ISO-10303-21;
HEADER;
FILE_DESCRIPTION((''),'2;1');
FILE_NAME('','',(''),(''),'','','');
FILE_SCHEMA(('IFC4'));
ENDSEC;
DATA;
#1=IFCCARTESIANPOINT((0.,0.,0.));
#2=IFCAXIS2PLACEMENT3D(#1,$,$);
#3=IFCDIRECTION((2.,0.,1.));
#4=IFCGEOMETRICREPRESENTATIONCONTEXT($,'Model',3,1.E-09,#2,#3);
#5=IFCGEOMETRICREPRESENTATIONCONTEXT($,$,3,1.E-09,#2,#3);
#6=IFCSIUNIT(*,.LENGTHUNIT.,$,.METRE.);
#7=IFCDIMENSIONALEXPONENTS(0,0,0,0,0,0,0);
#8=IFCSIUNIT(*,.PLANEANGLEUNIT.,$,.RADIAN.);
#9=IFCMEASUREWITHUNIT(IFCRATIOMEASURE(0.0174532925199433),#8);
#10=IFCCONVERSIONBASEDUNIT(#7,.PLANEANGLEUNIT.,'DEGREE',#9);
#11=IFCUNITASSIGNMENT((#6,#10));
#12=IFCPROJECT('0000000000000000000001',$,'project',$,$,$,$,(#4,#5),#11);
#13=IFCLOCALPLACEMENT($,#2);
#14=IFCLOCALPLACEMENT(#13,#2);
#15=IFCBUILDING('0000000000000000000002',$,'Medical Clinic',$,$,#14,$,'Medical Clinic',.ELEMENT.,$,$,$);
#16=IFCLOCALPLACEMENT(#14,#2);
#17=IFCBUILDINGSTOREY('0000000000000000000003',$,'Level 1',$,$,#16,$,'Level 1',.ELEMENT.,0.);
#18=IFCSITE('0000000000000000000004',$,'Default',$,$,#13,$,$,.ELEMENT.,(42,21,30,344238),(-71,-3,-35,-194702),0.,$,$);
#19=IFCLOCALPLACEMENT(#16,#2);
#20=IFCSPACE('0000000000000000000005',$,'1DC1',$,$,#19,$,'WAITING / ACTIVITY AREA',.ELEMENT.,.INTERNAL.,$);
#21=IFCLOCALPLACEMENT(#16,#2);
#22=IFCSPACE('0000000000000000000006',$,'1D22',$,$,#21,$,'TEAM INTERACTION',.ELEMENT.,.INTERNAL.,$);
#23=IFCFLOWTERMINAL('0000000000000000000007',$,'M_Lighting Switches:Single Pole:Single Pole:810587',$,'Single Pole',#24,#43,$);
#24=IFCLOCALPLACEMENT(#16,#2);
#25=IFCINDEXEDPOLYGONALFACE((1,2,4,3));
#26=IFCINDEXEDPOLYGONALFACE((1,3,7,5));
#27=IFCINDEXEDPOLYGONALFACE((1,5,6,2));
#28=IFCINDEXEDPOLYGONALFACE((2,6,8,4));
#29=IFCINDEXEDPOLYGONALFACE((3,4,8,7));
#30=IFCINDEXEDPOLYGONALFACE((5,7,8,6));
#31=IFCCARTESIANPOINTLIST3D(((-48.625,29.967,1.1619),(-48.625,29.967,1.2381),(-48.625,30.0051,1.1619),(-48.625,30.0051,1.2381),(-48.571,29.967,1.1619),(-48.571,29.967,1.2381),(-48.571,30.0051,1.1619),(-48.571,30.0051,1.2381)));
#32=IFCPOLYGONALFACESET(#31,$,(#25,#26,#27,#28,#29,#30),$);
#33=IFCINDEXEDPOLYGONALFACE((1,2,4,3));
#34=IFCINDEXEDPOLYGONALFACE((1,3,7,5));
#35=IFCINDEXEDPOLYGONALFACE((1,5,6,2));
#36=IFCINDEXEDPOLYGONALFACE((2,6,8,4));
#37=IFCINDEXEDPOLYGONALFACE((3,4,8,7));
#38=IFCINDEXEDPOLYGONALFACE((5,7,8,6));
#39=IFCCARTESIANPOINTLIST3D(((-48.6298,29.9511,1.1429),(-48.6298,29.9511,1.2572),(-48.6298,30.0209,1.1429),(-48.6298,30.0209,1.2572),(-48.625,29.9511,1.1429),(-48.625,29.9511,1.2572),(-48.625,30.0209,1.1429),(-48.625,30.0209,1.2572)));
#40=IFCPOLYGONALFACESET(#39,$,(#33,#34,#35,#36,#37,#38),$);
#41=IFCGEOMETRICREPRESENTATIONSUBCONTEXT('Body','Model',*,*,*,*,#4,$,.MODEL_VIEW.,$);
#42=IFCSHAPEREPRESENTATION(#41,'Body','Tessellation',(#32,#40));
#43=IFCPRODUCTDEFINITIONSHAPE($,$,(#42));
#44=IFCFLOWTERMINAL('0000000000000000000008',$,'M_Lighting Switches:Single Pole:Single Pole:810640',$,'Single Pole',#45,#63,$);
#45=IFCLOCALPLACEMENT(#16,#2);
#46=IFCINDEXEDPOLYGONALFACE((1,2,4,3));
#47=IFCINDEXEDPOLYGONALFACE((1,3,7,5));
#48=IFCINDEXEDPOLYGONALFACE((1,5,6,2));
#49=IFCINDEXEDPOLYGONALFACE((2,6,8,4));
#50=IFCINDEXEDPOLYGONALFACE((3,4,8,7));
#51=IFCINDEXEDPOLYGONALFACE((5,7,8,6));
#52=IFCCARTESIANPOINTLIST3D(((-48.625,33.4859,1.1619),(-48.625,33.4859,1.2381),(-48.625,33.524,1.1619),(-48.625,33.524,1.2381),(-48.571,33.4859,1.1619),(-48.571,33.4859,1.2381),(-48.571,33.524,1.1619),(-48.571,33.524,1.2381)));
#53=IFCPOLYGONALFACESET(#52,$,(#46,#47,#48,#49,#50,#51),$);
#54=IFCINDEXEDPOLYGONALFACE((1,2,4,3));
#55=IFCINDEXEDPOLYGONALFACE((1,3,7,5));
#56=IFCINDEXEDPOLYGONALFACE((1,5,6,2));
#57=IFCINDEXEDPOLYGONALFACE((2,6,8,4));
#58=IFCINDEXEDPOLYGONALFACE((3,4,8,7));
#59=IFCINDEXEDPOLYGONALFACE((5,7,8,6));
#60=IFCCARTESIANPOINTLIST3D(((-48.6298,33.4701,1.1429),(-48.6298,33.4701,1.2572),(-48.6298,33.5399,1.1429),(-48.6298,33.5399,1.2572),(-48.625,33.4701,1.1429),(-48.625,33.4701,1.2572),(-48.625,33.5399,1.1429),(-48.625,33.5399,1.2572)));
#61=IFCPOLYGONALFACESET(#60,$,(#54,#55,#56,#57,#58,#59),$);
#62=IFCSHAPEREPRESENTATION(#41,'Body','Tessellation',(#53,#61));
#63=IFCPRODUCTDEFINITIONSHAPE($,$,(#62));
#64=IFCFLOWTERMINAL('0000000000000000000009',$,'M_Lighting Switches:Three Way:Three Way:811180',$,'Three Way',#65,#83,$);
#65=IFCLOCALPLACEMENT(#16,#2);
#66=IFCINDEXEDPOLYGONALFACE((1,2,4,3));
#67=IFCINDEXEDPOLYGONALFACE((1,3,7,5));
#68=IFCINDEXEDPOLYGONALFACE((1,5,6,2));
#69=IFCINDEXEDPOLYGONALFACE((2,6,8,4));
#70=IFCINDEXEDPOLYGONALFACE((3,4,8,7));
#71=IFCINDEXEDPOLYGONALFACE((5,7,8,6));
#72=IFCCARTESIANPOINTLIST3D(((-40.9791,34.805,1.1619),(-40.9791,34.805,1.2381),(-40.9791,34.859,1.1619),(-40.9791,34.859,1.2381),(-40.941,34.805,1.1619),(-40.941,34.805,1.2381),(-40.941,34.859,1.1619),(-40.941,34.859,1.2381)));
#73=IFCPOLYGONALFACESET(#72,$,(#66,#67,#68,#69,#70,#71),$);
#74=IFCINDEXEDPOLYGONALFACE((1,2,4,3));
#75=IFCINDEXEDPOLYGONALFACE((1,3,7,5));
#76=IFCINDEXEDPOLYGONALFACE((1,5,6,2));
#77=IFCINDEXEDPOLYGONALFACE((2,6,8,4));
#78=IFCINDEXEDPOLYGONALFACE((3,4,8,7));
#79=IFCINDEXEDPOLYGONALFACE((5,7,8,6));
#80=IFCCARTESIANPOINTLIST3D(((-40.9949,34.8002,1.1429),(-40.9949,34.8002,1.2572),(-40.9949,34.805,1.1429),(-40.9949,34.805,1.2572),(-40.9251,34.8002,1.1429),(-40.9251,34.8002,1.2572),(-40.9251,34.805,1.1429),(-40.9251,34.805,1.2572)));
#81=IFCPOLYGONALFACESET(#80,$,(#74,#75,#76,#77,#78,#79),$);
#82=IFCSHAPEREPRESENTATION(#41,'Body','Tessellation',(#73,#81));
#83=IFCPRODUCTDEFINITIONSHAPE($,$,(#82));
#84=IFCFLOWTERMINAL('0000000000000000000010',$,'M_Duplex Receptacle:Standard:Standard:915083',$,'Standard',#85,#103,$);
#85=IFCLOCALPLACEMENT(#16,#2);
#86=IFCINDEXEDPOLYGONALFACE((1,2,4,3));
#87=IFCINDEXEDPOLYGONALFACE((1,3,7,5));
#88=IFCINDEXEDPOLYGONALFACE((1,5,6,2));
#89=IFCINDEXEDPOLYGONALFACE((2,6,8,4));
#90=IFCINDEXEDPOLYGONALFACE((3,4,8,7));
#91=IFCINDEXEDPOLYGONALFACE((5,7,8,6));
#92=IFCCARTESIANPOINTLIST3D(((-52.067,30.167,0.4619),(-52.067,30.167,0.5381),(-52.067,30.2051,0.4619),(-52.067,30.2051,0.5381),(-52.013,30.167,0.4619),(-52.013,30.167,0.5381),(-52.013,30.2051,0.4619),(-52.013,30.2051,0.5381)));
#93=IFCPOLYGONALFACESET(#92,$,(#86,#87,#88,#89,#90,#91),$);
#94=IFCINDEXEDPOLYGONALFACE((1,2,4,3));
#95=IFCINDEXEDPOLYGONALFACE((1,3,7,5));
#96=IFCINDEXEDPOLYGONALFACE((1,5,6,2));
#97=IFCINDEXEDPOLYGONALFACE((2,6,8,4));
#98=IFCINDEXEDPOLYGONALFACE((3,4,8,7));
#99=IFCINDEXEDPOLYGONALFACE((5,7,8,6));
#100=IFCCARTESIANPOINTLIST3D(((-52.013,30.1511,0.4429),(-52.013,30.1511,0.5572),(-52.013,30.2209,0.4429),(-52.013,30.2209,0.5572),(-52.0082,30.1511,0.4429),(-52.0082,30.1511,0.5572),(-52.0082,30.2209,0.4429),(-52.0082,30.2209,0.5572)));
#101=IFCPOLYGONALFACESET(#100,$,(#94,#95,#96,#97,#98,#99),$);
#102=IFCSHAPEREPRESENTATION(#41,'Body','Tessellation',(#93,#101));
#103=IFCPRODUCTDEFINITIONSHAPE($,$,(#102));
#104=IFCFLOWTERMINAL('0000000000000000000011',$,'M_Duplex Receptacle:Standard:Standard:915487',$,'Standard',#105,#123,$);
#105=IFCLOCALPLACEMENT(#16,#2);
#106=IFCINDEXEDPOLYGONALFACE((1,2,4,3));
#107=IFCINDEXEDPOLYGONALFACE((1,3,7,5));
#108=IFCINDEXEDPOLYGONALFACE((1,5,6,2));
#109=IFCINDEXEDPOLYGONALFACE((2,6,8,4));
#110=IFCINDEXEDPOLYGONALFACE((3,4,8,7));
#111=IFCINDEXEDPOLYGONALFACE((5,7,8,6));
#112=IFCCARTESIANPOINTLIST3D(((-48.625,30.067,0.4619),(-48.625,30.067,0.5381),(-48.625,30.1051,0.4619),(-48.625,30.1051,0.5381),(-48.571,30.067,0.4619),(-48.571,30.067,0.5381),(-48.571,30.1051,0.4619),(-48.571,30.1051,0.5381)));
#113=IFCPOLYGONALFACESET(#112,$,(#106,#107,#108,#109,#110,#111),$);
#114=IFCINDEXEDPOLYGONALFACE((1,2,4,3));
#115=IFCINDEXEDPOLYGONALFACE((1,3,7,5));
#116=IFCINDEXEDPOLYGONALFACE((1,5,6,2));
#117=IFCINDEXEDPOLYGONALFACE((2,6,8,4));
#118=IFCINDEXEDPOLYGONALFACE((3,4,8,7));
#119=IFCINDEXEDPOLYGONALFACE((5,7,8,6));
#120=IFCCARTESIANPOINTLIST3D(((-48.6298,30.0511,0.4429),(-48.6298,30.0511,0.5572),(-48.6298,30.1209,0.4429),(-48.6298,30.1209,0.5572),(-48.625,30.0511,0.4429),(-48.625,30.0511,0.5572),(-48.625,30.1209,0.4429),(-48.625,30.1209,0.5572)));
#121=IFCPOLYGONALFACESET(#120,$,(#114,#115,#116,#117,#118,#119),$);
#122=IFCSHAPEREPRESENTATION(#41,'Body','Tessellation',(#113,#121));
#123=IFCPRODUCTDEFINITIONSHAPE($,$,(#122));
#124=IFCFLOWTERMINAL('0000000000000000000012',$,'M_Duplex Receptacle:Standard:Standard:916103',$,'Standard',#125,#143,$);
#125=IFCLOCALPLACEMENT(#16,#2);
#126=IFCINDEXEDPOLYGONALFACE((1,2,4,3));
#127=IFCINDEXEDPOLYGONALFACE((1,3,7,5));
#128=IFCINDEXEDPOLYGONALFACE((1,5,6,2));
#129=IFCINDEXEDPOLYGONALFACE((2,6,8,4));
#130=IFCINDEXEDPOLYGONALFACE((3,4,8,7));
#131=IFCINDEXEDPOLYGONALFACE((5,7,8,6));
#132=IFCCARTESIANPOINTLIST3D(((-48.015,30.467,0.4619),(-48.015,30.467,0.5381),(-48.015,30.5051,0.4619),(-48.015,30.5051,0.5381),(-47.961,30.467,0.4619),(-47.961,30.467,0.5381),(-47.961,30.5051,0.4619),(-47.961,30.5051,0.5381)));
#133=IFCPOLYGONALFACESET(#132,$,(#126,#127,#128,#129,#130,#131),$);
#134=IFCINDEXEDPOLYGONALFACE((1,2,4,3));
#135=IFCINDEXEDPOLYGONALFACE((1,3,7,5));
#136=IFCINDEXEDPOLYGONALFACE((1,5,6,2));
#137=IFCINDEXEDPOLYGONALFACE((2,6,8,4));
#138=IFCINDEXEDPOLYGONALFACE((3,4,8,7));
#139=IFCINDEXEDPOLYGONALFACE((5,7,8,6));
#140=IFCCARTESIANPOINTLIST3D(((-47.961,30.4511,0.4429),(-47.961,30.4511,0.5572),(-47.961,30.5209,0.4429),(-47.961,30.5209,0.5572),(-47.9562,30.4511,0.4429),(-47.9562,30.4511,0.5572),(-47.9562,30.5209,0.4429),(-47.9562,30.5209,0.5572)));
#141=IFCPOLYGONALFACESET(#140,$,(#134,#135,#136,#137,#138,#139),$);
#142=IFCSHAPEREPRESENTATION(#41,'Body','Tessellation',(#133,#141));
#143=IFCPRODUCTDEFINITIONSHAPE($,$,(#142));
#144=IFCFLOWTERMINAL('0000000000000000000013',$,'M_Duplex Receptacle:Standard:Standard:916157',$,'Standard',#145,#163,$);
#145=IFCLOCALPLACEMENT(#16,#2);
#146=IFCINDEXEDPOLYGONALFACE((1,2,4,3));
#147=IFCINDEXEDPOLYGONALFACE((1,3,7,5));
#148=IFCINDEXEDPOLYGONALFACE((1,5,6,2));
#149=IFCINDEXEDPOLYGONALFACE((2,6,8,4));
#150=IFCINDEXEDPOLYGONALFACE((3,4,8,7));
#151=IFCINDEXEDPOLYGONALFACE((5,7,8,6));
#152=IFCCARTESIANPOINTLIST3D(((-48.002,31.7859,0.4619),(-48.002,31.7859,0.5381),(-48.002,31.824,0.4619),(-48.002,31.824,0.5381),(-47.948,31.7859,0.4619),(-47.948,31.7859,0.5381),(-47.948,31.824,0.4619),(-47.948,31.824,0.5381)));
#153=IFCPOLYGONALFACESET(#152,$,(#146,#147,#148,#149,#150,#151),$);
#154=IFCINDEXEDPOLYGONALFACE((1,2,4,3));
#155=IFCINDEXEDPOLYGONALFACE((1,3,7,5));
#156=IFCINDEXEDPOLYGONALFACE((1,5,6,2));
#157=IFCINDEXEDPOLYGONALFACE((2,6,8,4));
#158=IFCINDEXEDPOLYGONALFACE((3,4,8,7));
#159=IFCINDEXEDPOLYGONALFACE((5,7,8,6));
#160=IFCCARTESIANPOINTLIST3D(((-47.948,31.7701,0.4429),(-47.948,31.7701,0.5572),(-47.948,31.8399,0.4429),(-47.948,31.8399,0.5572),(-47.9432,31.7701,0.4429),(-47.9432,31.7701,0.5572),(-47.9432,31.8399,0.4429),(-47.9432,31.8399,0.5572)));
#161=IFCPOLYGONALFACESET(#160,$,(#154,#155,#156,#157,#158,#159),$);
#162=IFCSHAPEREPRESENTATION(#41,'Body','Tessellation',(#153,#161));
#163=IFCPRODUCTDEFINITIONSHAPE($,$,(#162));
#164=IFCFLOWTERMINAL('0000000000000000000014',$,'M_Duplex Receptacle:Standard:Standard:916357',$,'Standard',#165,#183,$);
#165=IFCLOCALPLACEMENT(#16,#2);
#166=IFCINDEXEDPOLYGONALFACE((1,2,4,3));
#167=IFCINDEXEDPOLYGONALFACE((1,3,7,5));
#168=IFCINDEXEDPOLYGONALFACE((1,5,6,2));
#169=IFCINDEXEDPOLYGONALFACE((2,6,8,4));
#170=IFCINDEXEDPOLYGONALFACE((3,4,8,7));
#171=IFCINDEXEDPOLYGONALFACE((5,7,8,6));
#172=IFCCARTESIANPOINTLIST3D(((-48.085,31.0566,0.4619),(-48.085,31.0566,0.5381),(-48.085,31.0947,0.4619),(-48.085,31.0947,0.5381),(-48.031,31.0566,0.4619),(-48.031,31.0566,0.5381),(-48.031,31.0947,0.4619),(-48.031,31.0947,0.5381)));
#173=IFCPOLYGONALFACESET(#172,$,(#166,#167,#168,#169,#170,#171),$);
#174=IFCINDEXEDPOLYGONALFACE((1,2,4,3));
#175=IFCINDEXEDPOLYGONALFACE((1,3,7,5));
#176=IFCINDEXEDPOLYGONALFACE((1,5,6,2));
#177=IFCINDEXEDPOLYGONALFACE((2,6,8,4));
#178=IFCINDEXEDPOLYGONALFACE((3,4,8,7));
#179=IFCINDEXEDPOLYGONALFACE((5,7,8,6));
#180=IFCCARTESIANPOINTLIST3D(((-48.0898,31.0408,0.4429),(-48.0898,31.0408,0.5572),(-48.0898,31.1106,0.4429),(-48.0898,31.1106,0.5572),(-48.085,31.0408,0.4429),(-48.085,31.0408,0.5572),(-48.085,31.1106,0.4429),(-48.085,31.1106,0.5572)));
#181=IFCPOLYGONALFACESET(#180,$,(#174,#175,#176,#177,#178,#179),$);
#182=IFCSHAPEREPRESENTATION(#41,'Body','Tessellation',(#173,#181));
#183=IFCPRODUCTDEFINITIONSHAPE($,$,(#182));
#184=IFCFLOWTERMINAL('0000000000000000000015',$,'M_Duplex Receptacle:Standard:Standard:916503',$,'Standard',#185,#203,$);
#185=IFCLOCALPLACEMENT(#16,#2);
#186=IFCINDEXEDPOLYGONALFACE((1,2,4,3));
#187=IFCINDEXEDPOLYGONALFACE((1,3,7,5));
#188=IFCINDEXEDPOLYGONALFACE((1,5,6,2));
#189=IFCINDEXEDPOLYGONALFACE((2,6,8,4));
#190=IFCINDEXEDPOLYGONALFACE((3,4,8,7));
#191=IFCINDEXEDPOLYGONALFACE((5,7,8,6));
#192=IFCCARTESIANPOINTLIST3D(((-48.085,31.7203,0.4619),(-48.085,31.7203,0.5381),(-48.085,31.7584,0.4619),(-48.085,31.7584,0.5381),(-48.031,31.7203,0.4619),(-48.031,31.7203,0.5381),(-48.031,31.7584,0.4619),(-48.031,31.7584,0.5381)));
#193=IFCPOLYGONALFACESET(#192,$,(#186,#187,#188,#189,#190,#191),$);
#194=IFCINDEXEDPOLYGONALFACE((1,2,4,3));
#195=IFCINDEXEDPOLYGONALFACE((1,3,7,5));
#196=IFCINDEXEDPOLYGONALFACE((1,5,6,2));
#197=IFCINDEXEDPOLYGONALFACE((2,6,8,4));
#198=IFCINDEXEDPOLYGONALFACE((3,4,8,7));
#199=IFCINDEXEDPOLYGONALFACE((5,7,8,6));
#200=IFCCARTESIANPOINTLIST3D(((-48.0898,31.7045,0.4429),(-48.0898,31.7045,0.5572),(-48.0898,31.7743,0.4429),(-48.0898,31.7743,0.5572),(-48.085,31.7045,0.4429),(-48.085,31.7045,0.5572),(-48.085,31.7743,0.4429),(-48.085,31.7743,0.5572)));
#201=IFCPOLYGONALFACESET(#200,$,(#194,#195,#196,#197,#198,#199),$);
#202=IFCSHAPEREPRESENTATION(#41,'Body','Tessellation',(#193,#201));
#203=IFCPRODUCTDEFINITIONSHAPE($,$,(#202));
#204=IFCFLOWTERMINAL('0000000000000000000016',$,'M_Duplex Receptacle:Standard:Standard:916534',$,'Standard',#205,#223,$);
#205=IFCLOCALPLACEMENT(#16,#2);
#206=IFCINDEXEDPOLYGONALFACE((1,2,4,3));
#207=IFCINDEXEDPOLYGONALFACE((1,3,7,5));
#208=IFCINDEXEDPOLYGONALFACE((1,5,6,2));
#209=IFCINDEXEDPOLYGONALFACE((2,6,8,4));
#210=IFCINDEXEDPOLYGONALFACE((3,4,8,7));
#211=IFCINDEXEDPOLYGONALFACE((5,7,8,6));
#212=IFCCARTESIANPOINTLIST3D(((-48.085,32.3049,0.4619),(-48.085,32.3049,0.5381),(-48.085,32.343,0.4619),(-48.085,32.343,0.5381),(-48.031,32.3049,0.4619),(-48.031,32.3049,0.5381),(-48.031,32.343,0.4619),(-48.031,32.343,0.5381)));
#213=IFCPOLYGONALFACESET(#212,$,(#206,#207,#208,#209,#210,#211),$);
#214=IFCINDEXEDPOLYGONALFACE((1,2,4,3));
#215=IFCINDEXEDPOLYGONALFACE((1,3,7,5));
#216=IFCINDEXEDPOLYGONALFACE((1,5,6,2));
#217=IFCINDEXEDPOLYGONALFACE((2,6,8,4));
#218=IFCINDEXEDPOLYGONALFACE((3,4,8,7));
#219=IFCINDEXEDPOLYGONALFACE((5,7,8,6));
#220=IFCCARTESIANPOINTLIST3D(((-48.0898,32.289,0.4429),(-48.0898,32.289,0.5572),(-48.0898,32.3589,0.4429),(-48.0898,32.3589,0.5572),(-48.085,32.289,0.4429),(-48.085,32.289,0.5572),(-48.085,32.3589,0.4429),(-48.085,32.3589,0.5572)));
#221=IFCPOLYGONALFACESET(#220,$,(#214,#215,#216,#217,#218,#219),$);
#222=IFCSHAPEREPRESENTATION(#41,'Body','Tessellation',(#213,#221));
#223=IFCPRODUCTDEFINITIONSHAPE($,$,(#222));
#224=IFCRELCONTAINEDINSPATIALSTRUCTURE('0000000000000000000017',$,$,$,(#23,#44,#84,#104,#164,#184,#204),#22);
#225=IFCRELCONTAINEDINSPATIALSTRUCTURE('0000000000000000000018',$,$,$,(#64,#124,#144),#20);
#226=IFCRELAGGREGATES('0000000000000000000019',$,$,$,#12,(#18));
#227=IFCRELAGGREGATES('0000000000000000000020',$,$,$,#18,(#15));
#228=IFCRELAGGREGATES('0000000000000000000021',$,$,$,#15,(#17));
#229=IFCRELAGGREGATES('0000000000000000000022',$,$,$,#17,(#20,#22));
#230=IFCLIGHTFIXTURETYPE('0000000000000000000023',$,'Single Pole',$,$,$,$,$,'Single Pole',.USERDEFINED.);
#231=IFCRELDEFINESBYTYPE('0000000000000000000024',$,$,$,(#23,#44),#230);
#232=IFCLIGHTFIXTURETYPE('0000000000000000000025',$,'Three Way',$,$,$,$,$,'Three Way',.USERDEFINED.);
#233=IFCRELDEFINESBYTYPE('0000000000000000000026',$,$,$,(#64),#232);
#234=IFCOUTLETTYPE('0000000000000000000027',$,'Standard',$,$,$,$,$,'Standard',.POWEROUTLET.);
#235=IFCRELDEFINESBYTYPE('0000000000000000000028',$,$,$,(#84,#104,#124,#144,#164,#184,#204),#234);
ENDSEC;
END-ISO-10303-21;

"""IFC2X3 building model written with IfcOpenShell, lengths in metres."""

from ifc_helpers import new_model, entity, si_unit, converted_unit, direction, frame, frame_2d, origin, origin_2d_with_axis, place, context, subcontext, project, spatial, rectangle, extrude, source, transform, mapped, type_object, type_shapes, element, save


model = new_model("IFC2X3")

# Units and contexts
model_context = context("Model", 3, precision=1e-09, world=origin(), true_north=direction((2.0, 0.0, 1.0)))
context_of_model = context(None, 3, precision=1e-09, world=origin(), true_north=direction((2.0, 0.0, 1.0)))
body_context = subcontext(model_context, "Body", "Model", "MODEL_VIEW")
ifc_project = project(units=[si_unit("LENGTHUNIT", "METRE"), converted_unit("PLANEANGLEUNIT", "DEGREE", entity("IfcRatioMeasure", 0.0174532925199433), si_unit("PLANEANGLEUNIT", "RADIAN"), dimensions=[0, 0, 0, 0, 0, 0, 0])], contexts=[model_context, context_of_model])

# Site, building, storey, space
site_placement = place(None, origin())
site = spatial("IfcSite", under=ifc_project, at=site_placement, Name="Default", CompositionType="ELEMENT", RefLatitude=(42, 21, 30, 344238), RefLongitude=(-71, -3, -35, -194702), RefElevation=0.0)
building_placement = place(site_placement, origin())
building = spatial("IfcBuilding", under=site, at=building_placement, Name="Medical Clinic", LongName="Medical Clinic", CompositionType="ELEMENT")
storey_placement = place(building_placement, origin())
storey = spatial("IfcBuildingStorey", under=building, at=storey_placement, Name="Level 1", LongName="Level 1", CompositionType="ELEMENT", Elevation=0.0)
space_1_placement = place(storey_placement, origin())
space_1 = spatial("IfcSpace", under=storey, at=space_1_placement, Name="1DC1", LongName="WAITING / ACTIVITY AREA", CompositionType="ELEMENT", InteriorOrExteriorSpace="INTERNAL")

# Shared definitions
space_2_placement = place(storey_placement, origin())
space_2 = spatial("IfcSpace", under=storey, at=space_2_placement, Name="1D22", LongName="TEAM INTERACTION", CompositionType="ELEMENT", InteriorOrExteriorSpace="INTERNAL")

# Flow terminals
light_fixture_type_1 = type_object("IfcLightFixtureType", Name="Single Pole", ElementType="Single Pole", PredefinedType="USERDEFINED")
shared_shape_1 = source(origin(), body_context, "Body", "SweptSolid", [
    extrude(rectangle(XDim=0.0381, YDim=0.0762, at=origin_2d_with_axis()), frame((0.0, 0.0, -0.054), z_axis=(0.0, 0.0, 1.0), x_axis=(-1.0, 0.0, 0.0)), (0.0, 0.0, 1.0), 0.054),
    extrude(rectangle(XDim=0.0698, YDim=0.1143, at=frame_2d((0.0, 0.0), x_axis=(1.0, 0.0))), frame((0.0, 0.0, 0.0), z_axis=(0.0, 0.0, 1.0), x_axis=(-1.0, 0.0, 0.0)), (0.0, 0.0, 1.0), 0.0048),
])
type_shapes(light_fixture_type_1, [shared_shape_1])
for number, where, z_axis, x_axis, name in (
    (1, (-48.625, 29.986, 1.2), (-1.0, 0.0, 0.0), (0.0, -1.0, 0.0), "M_Lighting Switches:Single Pole:Single Pole:810587"),
    (2, (-48.625, 33.505, 1.2), (-1.0, 0.0, 0.0), (0.0, -1.0, 0.0), "M_Lighting Switches:Single Pole:Single Pole:810640"),
):
    element("IfcFlowTerminal", number, at=place(space_2_placement, frame(where, z_axis=z_axis, x_axis=x_axis)), inside=space_2, type_object=light_fixture_type_1, Name=name, ObjectType="Single Pole", context=body_context, shape_type="MappedRepresentation", body=[
        mapped(shared_shape_1, transform((0.0, 0.0, 0.0), scale=1.0)),
    ])
light_fixture_type_2 = type_object("IfcLightFixtureType", Name="Three Way", ElementType="Three Way", PredefinedType="USERDEFINED")
shared_shape_2 = source(origin(), body_context, "Body", "SweptSolid", [
    extrude(rectangle(XDim=0.0381, YDim=0.0762, at=origin_2d_with_axis()), frame((0.0, 0.0, -0.054), z_axis=(0.0, 0.0, 1.0), x_axis=(-1.0, 0.0, 0.0)), (0.0, 0.0, 1.0), 0.054),
    extrude(rectangle(XDim=0.0698, YDim=0.1143, at=frame_2d((0.0, 0.0), x_axis=(1.0, 0.0))), frame((0.0, 0.0, 0.0), z_axis=(0.0, 0.0, 1.0), x_axis=(-1.0, 0.0, 0.0)), (0.0, 0.0, 1.0), 0.0048),
])
type_shapes(light_fixture_type_2, [shared_shape_2])
flow_terminal_1_placement = place(space_1_placement, frame((-40.96, 34.805, 1.2), z_axis=(0.0, -1.0, 0.0), x_axis=(1.0, 0.0, 0.0)))
element("IfcFlowTerminal", 3, at=flow_terminal_1_placement, inside=space_1, type_object=light_fixture_type_2, Name="M_Lighting Switches:Three Way:Three Way:811180", ObjectType="Three Way", context=body_context, shape_type="MappedRepresentation", body=[
    mapped(shared_shape_2, transform((0.0, 0.0, 0.0), scale=1.0)),
])
outlet_type = type_object("IfcOutletType", Name="Standard", ElementType="Standard", PredefinedType="POWEROUTLET")
shared_shape_3 = source(origin(), body_context, "Body", "SweptSolid", [
    extrude(rectangle(XDim=0.0381, YDim=0.0762, at=origin_2d_with_axis()), frame((0.0, 0.0, -0.054), z_axis=(0.0, 0.0, 1.0), x_axis=(-1.0, 0.0, 0.0)), (0.0, 0.0, 1.0), 0.054),
    extrude(rectangle(XDim=0.0698, YDim=0.1143, at=frame_2d((0.0, 0.0), x_axis=(1.0, 0.0))), frame((0.0, 0.0, 0.0), z_axis=(0.0, 0.0, 1.0), x_axis=(-1.0, 0.0, 0.0)), (0.0, 0.0, 1.0), 0.0048),
])
type_shapes(outlet_type, [shared_shape_3])
for number, where, z_axis, x_axis, name in (
    (4, (-52.013, 30.186, 0.5), (1.0, 0.0, 0.0), (0.0, 1.0, 0.0), "M_Duplex Receptacle:Standard:Standard:915083"),
    (5, (-48.625, 30.086, 0.5), (-1.0, 0.0, 0.0), (0.0, -1.0, 0.0), "M_Duplex Receptacle:Standard:Standard:915487"),
):
    element("IfcFlowTerminal", number, at=place(space_2_placement, frame(where, z_axis=z_axis, x_axis=x_axis)), inside=space_2, type_object=outlet_type, Name=name, ObjectType="Standard", context=body_context, shape_type="MappedRepresentation", body=[
        mapped(shared_shape_3, transform((0.0, 0.0, 0.0), scale=1.0)),
    ])
for number, where, z_axis, x_axis, name in (
    (6, (-47.961, 30.486, 0.5), (1.0, 0.0, 0.0), (0.0, 1.0, 0.0), "M_Duplex Receptacle:Standard:Standard:916103"),
    (7, (-47.948, 31.805, 0.5), (1.0, 0.0, 0.0), (0.0, 1.0, 0.0), "M_Duplex Receptacle:Standard:Standard:916157"),
):
    element("IfcFlowTerminal", number, at=place(space_1_placement, frame(where, z_axis=z_axis, x_axis=x_axis)), inside=space_1, type_object=outlet_type, Name=name, ObjectType="Standard", context=body_context, shape_type="MappedRepresentation", body=[
        mapped(shared_shape_3, transform((0.0, 0.0, 0.0), scale=1.0)),
    ])
for number, where, z_axis, x_axis, name in (
    (8, (-48.085, 31.0757, 0.5), (-1.0, 0.0, 0.0), (0.0, -1.0, 0.0), "M_Duplex Receptacle:Standard:Standard:916357"),
    (9, (-48.085, 31.7394, 0.5), (-1.0, 0.0, 0.0), (0.0, -1.0, 0.0), "M_Duplex Receptacle:Standard:Standard:916503"),
    (10, (-48.085, 32.3239, 0.5), (-1.0, 0.0, 0.0), (0.0, -1.0, 0.0), "M_Duplex Receptacle:Standard:Standard:916534"),
):
    element("IfcFlowTerminal", number, at=place(space_2_placement, frame(where, z_axis=z_axis, x_axis=x_axis)), inside=space_2, type_object=outlet_type, Name=name, ObjectType="Standard", context=body_context, shape_type="MappedRepresentation", body=[
        mapped(shared_shape_3, transform((0.0, 0.0, 0.0), scale=1.0)),
    ])

save(model, "model.ifc")
